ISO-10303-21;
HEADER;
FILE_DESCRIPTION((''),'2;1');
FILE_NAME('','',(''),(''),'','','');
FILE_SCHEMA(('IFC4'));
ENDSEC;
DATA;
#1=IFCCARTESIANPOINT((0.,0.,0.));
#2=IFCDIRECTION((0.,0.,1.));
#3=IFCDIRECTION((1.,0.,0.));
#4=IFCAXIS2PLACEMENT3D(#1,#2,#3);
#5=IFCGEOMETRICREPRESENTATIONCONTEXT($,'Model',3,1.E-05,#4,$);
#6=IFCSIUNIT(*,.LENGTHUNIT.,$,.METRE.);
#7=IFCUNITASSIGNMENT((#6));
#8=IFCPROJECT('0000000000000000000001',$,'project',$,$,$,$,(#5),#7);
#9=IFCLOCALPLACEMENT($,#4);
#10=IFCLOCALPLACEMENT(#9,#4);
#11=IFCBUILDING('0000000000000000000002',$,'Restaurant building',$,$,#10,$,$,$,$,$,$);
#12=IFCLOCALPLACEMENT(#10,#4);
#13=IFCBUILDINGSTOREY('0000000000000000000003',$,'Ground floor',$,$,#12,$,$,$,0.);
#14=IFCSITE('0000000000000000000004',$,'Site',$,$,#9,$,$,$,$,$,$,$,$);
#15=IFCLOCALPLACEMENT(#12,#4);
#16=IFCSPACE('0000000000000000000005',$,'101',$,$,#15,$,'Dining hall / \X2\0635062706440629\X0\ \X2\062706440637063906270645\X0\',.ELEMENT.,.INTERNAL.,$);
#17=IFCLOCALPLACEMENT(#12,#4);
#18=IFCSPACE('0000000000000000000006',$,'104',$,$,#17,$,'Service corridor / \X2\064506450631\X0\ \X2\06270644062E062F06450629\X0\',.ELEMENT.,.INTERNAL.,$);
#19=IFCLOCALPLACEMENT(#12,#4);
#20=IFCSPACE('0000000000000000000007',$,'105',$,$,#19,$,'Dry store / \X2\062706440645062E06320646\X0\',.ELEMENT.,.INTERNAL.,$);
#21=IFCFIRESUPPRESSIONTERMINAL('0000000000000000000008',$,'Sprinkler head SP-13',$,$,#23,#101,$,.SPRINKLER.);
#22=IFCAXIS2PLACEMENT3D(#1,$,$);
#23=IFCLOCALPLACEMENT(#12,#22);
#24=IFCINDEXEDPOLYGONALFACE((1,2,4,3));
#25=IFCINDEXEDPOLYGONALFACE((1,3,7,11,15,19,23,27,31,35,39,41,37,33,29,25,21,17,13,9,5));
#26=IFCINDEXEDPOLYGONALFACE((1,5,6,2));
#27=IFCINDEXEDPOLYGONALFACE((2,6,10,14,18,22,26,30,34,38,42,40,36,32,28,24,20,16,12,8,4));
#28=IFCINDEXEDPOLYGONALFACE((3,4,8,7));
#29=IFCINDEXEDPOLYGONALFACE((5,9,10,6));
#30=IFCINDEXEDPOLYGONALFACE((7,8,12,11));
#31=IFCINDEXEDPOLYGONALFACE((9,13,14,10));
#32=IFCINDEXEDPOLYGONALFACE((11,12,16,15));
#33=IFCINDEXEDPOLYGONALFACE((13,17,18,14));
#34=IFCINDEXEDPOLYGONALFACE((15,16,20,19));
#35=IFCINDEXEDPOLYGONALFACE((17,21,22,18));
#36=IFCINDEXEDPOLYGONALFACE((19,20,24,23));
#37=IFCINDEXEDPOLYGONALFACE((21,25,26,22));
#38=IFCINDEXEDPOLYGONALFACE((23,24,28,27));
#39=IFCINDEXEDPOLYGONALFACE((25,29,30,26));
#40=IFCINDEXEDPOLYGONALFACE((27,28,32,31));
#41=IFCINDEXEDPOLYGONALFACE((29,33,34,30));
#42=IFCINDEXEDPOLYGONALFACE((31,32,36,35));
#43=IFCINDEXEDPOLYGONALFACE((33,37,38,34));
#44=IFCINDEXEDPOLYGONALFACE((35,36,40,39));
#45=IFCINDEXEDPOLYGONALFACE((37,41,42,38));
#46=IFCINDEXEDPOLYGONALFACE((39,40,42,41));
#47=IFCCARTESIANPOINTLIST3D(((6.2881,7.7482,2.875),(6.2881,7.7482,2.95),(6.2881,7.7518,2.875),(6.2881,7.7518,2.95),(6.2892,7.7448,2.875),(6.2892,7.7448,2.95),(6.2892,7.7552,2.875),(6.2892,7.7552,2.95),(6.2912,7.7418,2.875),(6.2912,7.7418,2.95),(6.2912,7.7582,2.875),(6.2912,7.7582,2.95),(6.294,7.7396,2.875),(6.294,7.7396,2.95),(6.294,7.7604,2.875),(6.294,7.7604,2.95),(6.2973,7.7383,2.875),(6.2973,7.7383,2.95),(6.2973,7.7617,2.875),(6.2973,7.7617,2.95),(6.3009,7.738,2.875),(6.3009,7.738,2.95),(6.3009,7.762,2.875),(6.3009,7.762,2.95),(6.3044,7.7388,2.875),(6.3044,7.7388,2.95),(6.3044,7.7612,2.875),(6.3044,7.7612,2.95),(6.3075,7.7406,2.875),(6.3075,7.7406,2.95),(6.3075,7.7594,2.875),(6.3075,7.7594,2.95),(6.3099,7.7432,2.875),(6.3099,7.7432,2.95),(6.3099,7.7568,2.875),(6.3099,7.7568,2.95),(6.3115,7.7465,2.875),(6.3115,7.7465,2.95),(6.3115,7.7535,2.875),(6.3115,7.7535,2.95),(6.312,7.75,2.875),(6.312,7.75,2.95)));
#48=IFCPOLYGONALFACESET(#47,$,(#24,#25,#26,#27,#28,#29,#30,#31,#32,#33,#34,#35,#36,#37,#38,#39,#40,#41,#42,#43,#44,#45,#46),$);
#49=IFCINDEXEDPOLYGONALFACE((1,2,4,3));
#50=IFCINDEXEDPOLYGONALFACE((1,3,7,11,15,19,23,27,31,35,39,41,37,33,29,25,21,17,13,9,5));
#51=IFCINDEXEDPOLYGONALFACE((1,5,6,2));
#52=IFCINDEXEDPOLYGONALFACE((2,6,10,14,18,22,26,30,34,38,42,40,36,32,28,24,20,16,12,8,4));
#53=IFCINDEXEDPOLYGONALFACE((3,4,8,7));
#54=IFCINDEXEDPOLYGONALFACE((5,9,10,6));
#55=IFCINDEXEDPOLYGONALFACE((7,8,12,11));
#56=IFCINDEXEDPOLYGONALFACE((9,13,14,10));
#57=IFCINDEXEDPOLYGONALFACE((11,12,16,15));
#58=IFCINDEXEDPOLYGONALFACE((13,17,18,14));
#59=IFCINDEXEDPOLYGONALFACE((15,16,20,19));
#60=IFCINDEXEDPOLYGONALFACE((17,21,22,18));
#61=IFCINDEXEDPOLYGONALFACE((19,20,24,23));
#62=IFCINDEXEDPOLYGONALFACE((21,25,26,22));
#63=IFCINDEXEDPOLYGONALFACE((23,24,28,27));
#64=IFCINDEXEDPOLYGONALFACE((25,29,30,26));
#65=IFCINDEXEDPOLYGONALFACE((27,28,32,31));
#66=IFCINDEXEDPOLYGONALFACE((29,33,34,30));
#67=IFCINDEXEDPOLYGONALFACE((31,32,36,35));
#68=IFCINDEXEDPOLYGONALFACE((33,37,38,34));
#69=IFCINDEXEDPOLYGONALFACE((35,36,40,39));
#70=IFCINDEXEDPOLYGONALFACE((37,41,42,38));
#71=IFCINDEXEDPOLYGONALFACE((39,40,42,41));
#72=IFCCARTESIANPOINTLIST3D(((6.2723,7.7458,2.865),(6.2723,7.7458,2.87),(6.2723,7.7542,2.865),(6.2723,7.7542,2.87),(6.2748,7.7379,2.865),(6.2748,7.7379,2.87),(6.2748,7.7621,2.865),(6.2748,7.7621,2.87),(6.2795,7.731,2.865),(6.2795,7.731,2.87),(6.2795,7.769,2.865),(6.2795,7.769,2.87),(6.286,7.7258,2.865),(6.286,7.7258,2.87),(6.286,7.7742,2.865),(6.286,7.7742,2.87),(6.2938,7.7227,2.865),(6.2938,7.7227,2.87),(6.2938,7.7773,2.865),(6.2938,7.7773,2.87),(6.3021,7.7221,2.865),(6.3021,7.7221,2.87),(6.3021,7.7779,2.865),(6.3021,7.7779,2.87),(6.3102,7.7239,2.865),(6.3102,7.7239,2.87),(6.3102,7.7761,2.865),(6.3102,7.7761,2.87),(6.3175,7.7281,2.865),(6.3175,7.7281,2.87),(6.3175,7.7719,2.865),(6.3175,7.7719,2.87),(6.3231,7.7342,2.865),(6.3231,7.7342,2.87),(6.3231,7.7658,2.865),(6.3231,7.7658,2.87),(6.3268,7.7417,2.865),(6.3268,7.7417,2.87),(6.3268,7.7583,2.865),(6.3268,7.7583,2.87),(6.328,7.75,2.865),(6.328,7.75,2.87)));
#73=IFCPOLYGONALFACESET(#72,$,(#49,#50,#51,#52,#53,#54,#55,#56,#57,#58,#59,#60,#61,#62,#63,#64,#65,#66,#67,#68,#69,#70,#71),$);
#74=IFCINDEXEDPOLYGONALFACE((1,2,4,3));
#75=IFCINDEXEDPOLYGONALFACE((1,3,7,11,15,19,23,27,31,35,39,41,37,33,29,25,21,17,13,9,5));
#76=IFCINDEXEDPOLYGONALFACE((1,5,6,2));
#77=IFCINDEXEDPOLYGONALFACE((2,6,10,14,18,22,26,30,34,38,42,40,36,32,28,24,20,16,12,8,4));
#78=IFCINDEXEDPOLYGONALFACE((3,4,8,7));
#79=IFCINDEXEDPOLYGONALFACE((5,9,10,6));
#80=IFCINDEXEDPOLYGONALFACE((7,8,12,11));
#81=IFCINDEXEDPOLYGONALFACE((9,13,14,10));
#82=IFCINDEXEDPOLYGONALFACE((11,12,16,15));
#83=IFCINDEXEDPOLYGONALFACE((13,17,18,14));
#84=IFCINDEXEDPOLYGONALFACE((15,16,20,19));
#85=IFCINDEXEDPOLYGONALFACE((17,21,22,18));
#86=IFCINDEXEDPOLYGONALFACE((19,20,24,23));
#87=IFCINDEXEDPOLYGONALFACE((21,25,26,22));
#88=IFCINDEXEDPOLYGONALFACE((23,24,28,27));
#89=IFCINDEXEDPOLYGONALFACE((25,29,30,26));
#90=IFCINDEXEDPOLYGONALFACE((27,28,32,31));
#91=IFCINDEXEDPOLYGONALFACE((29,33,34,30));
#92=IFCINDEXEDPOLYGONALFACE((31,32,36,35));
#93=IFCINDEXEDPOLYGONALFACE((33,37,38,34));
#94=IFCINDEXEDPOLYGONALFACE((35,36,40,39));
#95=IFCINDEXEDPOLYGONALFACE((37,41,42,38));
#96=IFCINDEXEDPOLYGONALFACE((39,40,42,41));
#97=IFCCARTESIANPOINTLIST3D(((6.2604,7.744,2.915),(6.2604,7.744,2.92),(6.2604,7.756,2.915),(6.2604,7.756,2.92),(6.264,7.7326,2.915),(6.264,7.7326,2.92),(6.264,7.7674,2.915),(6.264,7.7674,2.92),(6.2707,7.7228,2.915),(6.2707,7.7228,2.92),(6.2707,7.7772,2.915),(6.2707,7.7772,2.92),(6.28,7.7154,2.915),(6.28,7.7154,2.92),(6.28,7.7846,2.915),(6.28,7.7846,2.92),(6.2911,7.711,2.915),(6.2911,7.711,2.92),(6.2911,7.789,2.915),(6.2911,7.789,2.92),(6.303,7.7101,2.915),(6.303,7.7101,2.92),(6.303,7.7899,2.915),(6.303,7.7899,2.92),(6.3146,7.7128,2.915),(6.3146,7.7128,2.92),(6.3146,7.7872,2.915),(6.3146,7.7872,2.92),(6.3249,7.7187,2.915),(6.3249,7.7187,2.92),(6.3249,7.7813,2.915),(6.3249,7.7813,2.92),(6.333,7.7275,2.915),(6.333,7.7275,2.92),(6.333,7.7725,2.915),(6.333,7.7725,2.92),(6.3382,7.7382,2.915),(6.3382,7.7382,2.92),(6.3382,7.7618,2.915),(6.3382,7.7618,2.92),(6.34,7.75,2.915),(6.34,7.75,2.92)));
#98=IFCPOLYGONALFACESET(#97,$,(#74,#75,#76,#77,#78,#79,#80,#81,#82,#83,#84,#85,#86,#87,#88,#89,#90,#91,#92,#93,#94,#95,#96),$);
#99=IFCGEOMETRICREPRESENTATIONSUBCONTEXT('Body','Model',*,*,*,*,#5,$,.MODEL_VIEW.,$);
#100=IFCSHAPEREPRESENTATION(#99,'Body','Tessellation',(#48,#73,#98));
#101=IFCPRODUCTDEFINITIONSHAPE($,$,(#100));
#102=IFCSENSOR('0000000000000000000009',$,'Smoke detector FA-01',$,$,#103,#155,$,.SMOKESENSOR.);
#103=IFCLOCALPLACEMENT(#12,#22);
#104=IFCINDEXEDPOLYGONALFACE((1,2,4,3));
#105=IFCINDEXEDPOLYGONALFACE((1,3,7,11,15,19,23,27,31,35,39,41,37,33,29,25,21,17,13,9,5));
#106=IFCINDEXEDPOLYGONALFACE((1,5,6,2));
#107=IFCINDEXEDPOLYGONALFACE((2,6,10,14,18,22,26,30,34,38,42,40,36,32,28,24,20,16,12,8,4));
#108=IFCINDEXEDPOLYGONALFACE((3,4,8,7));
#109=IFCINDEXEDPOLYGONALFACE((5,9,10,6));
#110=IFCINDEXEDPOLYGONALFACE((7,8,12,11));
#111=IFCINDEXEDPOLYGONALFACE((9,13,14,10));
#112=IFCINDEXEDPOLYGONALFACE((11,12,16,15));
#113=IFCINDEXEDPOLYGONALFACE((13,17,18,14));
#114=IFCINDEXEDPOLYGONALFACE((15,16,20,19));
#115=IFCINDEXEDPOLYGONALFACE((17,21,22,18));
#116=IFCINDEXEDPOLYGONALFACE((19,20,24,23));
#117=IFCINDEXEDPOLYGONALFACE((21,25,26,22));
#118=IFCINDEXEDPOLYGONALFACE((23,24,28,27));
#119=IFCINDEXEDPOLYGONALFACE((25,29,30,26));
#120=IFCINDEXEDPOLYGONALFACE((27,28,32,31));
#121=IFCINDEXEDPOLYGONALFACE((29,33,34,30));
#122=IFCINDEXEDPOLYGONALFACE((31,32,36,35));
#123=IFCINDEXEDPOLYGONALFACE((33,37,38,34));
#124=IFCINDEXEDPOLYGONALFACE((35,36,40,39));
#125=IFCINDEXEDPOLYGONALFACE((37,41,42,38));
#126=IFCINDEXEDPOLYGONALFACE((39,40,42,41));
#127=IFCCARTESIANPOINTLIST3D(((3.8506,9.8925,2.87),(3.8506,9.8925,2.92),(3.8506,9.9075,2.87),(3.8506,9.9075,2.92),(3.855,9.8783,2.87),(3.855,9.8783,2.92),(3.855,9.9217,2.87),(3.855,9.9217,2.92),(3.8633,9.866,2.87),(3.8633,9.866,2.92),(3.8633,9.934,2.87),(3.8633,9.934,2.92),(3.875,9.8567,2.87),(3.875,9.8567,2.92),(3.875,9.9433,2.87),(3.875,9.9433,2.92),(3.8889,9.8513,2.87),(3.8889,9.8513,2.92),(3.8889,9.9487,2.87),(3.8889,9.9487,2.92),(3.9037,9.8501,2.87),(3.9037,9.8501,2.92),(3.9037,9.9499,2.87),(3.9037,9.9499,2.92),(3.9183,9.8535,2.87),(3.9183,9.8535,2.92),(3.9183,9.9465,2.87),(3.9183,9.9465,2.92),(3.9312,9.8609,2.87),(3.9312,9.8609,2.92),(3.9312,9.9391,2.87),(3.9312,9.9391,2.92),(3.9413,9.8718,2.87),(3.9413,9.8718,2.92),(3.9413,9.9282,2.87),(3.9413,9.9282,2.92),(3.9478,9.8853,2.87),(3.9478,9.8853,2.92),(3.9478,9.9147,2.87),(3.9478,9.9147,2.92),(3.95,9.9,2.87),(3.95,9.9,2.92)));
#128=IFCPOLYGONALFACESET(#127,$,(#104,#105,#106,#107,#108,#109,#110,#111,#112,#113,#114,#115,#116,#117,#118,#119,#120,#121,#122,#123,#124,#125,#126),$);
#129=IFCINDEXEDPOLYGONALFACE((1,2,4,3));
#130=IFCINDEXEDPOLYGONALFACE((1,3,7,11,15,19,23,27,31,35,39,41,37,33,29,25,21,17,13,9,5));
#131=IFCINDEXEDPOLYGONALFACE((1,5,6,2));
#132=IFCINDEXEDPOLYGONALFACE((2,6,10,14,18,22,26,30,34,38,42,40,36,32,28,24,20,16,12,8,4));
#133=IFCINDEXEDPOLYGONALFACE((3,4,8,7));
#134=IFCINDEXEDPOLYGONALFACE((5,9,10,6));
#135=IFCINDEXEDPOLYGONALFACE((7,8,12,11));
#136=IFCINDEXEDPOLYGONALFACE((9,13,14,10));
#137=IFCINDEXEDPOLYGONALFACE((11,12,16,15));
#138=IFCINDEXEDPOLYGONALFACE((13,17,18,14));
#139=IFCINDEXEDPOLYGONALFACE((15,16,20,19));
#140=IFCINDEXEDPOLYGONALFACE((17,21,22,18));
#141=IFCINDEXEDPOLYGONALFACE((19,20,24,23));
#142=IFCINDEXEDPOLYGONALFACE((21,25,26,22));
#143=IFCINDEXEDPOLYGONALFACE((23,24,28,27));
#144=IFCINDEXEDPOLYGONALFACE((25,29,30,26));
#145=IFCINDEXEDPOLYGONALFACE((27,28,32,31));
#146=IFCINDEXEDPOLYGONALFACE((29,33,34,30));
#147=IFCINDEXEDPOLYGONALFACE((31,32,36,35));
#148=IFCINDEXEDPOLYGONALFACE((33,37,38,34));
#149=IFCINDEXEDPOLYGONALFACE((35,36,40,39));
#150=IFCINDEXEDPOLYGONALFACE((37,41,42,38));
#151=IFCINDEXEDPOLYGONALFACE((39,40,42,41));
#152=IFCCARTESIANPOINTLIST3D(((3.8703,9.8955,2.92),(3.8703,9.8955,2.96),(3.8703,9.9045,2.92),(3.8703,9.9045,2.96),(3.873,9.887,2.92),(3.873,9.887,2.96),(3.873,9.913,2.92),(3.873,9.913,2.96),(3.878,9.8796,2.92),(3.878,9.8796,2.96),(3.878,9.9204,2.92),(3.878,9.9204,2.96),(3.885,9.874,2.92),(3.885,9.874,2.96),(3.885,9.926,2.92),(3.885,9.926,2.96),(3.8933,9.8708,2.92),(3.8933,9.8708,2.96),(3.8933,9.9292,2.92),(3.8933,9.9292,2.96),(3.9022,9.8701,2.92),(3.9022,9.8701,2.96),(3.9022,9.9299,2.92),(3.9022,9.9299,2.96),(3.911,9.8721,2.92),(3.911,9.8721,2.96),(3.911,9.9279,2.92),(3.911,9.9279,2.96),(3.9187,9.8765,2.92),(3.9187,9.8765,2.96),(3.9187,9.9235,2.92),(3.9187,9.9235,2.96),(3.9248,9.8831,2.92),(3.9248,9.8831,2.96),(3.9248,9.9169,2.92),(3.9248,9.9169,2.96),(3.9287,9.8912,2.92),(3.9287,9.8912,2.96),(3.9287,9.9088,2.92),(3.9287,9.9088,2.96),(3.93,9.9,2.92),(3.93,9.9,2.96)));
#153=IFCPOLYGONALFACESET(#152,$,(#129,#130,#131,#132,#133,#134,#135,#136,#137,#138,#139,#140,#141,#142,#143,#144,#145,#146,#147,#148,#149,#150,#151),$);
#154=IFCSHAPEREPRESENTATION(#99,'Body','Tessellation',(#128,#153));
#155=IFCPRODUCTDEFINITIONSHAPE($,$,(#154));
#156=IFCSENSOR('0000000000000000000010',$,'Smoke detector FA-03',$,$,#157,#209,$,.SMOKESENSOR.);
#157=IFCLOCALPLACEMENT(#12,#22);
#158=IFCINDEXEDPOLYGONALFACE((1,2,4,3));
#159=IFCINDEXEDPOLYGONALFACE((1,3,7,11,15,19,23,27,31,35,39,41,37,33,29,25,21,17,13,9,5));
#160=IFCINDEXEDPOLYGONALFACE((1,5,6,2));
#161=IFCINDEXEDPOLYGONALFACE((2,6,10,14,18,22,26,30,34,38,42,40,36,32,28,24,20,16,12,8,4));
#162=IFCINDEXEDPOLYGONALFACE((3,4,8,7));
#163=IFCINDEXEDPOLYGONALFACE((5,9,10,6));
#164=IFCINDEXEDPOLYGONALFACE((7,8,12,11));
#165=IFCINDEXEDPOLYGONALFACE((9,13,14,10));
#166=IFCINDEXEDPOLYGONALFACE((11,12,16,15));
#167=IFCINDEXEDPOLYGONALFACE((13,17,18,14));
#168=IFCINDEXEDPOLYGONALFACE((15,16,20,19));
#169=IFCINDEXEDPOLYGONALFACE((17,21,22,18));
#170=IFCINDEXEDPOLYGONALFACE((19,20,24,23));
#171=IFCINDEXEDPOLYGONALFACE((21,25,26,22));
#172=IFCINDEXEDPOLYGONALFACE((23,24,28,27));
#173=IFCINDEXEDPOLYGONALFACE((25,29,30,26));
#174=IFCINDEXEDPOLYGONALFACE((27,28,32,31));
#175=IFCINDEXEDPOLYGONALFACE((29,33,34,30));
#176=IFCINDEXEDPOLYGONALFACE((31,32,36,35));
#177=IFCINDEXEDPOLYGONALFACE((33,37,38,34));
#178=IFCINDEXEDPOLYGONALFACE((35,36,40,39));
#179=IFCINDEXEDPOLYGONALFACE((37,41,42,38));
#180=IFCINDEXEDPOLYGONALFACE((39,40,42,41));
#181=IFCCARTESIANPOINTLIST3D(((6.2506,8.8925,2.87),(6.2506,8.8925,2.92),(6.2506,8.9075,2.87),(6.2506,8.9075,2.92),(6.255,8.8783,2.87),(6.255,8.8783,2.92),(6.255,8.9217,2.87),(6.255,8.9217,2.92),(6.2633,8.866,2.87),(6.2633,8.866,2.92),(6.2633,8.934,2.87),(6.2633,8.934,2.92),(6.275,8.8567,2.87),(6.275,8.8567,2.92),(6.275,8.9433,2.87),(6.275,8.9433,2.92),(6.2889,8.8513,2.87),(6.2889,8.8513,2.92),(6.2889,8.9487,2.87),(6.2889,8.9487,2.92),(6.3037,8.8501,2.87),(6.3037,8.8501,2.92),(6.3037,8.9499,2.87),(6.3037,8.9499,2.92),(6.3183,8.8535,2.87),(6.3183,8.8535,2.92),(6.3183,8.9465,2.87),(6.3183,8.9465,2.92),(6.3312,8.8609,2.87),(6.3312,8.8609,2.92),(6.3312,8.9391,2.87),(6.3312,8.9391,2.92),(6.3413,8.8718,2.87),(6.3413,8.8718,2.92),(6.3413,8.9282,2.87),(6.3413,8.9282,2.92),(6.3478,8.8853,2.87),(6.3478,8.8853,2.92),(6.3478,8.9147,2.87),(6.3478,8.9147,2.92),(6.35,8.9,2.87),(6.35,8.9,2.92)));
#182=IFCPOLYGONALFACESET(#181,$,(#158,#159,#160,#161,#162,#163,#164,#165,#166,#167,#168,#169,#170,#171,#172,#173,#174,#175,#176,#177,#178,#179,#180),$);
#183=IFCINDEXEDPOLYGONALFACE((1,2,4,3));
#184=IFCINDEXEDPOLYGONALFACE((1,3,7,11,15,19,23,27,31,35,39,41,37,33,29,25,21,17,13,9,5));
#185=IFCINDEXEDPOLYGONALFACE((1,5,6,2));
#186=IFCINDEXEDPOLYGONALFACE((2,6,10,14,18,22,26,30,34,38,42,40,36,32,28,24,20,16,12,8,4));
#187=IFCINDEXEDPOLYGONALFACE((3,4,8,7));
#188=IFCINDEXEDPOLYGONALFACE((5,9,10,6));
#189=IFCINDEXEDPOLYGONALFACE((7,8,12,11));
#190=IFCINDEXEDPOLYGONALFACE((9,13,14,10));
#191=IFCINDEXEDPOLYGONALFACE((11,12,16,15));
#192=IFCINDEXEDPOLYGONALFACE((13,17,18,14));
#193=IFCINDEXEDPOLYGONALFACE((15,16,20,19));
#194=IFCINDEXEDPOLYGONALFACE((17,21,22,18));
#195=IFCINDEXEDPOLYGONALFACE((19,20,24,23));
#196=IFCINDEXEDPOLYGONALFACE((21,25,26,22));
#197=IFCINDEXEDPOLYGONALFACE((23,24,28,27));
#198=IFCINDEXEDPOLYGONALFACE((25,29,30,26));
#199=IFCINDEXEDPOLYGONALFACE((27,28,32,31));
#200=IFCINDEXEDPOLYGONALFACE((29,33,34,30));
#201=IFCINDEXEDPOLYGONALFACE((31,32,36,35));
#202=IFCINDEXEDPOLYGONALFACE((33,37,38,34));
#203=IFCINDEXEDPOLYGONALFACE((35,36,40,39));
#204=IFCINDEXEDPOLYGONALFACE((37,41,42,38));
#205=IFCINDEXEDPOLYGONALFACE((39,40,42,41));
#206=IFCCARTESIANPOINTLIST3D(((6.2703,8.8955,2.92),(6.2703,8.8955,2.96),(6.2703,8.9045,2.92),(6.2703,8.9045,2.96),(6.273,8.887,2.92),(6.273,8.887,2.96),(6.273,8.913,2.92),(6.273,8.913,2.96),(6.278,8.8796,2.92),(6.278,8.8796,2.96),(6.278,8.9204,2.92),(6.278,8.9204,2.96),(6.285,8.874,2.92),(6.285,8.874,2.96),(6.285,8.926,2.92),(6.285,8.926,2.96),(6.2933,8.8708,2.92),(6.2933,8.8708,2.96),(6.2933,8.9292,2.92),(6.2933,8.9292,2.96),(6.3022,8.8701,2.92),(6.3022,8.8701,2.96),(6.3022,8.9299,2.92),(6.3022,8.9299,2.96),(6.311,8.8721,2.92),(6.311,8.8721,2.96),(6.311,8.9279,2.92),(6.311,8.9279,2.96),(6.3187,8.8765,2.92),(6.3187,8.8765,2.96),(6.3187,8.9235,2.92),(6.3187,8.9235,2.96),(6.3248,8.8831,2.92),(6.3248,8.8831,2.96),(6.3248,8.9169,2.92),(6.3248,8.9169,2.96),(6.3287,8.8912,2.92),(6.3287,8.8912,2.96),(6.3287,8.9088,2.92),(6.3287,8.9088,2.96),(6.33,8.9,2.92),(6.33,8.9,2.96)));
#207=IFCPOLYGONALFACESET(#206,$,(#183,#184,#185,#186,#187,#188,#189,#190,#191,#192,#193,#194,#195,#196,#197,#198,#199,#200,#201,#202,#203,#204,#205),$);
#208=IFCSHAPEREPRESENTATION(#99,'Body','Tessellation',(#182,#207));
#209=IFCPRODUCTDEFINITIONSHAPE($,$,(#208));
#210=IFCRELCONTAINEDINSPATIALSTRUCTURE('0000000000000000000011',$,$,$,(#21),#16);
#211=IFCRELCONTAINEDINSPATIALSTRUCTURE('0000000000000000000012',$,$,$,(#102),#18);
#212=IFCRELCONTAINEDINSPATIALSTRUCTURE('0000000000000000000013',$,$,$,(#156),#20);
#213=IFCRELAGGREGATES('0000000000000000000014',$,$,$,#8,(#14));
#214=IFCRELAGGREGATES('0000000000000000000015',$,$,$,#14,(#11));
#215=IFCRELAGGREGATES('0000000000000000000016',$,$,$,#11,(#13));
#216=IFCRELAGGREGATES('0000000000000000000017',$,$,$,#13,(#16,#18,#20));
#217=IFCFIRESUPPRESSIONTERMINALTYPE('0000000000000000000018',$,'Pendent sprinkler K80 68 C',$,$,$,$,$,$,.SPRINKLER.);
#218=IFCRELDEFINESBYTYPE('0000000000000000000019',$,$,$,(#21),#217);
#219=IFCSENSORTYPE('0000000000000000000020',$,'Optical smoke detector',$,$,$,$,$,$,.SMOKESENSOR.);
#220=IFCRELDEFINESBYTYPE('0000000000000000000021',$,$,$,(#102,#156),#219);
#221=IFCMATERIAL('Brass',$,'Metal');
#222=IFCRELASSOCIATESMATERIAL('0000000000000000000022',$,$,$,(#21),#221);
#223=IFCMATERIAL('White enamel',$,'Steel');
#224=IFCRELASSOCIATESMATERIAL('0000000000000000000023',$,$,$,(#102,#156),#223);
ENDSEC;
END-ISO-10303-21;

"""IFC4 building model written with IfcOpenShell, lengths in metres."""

from ifc_helpers import new_model, si_unit, frame, origin, origin_with_axes, origin_2d, place, context, subcontext, project, spatial, circle, extrude, source, transform, mapped, material, type_object, type_shapes, element, save


model = new_model("IFC4")

# Units and contexts
model_context = context("Model", 3, precision=1e-05, world=origin_with_axes())
body_context = subcontext(model_context, "Body", "Model", "MODEL_VIEW")
ifc_project = project(units=[si_unit("LENGTHUNIT", "METRE")], contexts=[model_context])

# Site, building, storey
site_placement = place(None, origin_with_axes())
site = spatial("IfcSite", under=ifc_project, at=site_placement, Name="Site")
building_placement = place(site_placement, origin_with_axes())
building = spatial("IfcBuilding", under=site, at=building_placement, Name="Restaurant building")
storey_placement = place(building_placement, origin_with_axes())
storey = spatial("IfcBuildingStorey", under=building, at=storey_placement, Name="Ground floor", Elevation=0.0)

# Shared definitions
ifc_material_1 = material(Name="White enamel", Category="Steel")

# Shared definitions
space_1_placement = place(storey_placement, origin_with_axes())
space_1 = spatial("IfcSpace", under=storey, at=space_1_placement, Name="101", LongName="Dining hall / صالة الطعام", CompositionType="ELEMENT", PredefinedType="INTERNAL")

# Shared definitions
space_2_placement = place(storey_placement, origin_with_axes())
space_2 = spatial("IfcSpace", under=storey, at=space_2_placement, Name="104", LongName="Service corridor / ممر الخدمة", CompositionType="ELEMENT", PredefinedType="INTERNAL")

# Fire suppression terminal
ifc_material_2 = material(Name="Brass", Category="Metal")
fire_suppression_terminal_type = type_object("IfcFireSuppressionTerminalType", Name="Pendent sprinkler K80 68 C", PredefinedType="SPRINKLER")
shared_shape_1 = source(origin(), body_context, "Body", "SweptSolid", [
    extrude(circle(Radius=0.012, at=origin_2d()), frame((0.0, 0.0, -0.075)), (0.0, 0.0, 1.0), 0.075),
    extrude(circle(Radius=0.028, at=origin_2d()), frame((0.0, 0.0, -0.085)), (0.0, 0.0, 1.0), 0.005),
    extrude(circle(Radius=0.04, at=origin_2d()), frame((0.0, 0.0, -0.035)), (0.0, 0.0, 1.0), 0.005),
])
type_shapes(fire_suppression_terminal_type, [shared_shape_1])
for number, where, name in (
    (1, (6.3, 7.75, 2.95), "Sprinkler head SP-13"),
):
    element("IfcFireSuppressionTerminal", number, at=place(storey_placement, frame(where)), inside=space_1, type_object=fire_suppression_terminal_type, material=ifc_material_2, Name=name, PredefinedType="SPRINKLER", context=body_context, shape_type="MappedRepresentation", body=[
        mapped(shared_shape_1, transform((0.0, 0.0, 0.0))),
    ])

# Sensor
sensor_type = type_object("IfcSensorType", Name="Optical smoke detector", PredefinedType="SMOKESENSOR")
shared_shape_2 = source(origin(), body_context, "Body", "SweptSolid", [
    extrude(circle(Radius=0.05, at=origin_2d()), frame((0.0, 0.0, -0.09)), (0.0, 0.0, 1.0), 0.05),
    extrude(circle(Radius=0.03, at=origin_2d()), frame((0.0, 0.0, -0.04)), (0.0, 0.0, 1.0), 0.04),
])
type_shapes(sensor_type, [shared_shape_2])
sensor_1_placement = place(storey_placement, frame((3.9, 9.9, 2.96)))
element("IfcSensor", 2, at=sensor_1_placement, inside=space_2, type_object=sensor_type, material=ifc_material_1, Name="Smoke detector FA-01", PredefinedType="SMOKESENSOR", context=body_context, shape_type="MappedRepresentation", body=[
    mapped(shared_shape_2, transform((0.0, 0.0, 0.0))),
])

# Shared definitions
space_3_placement = place(storey_placement, origin_with_axes())
space_3 = spatial("IfcSpace", under=storey, at=space_3_placement, Name="105", LongName="Dry store / المخزن", CompositionType="ELEMENT", PredefinedType="INTERNAL")

# Sensor
sensor_2_placement = place(storey_placement, frame((6.3, 8.9, 2.96)))
element("IfcSensor", 3, at=sensor_2_placement, inside=space_3, type_object=sensor_type, material=ifc_material_1, Name="Smoke detector FA-03", PredefinedType="SMOKESENSOR", context=body_context, shape_type="MappedRepresentation", body=[
    mapped(shared_shape_2, transform((0.0, 0.0, 0.0))),
])

save(model, "model.ifc")
